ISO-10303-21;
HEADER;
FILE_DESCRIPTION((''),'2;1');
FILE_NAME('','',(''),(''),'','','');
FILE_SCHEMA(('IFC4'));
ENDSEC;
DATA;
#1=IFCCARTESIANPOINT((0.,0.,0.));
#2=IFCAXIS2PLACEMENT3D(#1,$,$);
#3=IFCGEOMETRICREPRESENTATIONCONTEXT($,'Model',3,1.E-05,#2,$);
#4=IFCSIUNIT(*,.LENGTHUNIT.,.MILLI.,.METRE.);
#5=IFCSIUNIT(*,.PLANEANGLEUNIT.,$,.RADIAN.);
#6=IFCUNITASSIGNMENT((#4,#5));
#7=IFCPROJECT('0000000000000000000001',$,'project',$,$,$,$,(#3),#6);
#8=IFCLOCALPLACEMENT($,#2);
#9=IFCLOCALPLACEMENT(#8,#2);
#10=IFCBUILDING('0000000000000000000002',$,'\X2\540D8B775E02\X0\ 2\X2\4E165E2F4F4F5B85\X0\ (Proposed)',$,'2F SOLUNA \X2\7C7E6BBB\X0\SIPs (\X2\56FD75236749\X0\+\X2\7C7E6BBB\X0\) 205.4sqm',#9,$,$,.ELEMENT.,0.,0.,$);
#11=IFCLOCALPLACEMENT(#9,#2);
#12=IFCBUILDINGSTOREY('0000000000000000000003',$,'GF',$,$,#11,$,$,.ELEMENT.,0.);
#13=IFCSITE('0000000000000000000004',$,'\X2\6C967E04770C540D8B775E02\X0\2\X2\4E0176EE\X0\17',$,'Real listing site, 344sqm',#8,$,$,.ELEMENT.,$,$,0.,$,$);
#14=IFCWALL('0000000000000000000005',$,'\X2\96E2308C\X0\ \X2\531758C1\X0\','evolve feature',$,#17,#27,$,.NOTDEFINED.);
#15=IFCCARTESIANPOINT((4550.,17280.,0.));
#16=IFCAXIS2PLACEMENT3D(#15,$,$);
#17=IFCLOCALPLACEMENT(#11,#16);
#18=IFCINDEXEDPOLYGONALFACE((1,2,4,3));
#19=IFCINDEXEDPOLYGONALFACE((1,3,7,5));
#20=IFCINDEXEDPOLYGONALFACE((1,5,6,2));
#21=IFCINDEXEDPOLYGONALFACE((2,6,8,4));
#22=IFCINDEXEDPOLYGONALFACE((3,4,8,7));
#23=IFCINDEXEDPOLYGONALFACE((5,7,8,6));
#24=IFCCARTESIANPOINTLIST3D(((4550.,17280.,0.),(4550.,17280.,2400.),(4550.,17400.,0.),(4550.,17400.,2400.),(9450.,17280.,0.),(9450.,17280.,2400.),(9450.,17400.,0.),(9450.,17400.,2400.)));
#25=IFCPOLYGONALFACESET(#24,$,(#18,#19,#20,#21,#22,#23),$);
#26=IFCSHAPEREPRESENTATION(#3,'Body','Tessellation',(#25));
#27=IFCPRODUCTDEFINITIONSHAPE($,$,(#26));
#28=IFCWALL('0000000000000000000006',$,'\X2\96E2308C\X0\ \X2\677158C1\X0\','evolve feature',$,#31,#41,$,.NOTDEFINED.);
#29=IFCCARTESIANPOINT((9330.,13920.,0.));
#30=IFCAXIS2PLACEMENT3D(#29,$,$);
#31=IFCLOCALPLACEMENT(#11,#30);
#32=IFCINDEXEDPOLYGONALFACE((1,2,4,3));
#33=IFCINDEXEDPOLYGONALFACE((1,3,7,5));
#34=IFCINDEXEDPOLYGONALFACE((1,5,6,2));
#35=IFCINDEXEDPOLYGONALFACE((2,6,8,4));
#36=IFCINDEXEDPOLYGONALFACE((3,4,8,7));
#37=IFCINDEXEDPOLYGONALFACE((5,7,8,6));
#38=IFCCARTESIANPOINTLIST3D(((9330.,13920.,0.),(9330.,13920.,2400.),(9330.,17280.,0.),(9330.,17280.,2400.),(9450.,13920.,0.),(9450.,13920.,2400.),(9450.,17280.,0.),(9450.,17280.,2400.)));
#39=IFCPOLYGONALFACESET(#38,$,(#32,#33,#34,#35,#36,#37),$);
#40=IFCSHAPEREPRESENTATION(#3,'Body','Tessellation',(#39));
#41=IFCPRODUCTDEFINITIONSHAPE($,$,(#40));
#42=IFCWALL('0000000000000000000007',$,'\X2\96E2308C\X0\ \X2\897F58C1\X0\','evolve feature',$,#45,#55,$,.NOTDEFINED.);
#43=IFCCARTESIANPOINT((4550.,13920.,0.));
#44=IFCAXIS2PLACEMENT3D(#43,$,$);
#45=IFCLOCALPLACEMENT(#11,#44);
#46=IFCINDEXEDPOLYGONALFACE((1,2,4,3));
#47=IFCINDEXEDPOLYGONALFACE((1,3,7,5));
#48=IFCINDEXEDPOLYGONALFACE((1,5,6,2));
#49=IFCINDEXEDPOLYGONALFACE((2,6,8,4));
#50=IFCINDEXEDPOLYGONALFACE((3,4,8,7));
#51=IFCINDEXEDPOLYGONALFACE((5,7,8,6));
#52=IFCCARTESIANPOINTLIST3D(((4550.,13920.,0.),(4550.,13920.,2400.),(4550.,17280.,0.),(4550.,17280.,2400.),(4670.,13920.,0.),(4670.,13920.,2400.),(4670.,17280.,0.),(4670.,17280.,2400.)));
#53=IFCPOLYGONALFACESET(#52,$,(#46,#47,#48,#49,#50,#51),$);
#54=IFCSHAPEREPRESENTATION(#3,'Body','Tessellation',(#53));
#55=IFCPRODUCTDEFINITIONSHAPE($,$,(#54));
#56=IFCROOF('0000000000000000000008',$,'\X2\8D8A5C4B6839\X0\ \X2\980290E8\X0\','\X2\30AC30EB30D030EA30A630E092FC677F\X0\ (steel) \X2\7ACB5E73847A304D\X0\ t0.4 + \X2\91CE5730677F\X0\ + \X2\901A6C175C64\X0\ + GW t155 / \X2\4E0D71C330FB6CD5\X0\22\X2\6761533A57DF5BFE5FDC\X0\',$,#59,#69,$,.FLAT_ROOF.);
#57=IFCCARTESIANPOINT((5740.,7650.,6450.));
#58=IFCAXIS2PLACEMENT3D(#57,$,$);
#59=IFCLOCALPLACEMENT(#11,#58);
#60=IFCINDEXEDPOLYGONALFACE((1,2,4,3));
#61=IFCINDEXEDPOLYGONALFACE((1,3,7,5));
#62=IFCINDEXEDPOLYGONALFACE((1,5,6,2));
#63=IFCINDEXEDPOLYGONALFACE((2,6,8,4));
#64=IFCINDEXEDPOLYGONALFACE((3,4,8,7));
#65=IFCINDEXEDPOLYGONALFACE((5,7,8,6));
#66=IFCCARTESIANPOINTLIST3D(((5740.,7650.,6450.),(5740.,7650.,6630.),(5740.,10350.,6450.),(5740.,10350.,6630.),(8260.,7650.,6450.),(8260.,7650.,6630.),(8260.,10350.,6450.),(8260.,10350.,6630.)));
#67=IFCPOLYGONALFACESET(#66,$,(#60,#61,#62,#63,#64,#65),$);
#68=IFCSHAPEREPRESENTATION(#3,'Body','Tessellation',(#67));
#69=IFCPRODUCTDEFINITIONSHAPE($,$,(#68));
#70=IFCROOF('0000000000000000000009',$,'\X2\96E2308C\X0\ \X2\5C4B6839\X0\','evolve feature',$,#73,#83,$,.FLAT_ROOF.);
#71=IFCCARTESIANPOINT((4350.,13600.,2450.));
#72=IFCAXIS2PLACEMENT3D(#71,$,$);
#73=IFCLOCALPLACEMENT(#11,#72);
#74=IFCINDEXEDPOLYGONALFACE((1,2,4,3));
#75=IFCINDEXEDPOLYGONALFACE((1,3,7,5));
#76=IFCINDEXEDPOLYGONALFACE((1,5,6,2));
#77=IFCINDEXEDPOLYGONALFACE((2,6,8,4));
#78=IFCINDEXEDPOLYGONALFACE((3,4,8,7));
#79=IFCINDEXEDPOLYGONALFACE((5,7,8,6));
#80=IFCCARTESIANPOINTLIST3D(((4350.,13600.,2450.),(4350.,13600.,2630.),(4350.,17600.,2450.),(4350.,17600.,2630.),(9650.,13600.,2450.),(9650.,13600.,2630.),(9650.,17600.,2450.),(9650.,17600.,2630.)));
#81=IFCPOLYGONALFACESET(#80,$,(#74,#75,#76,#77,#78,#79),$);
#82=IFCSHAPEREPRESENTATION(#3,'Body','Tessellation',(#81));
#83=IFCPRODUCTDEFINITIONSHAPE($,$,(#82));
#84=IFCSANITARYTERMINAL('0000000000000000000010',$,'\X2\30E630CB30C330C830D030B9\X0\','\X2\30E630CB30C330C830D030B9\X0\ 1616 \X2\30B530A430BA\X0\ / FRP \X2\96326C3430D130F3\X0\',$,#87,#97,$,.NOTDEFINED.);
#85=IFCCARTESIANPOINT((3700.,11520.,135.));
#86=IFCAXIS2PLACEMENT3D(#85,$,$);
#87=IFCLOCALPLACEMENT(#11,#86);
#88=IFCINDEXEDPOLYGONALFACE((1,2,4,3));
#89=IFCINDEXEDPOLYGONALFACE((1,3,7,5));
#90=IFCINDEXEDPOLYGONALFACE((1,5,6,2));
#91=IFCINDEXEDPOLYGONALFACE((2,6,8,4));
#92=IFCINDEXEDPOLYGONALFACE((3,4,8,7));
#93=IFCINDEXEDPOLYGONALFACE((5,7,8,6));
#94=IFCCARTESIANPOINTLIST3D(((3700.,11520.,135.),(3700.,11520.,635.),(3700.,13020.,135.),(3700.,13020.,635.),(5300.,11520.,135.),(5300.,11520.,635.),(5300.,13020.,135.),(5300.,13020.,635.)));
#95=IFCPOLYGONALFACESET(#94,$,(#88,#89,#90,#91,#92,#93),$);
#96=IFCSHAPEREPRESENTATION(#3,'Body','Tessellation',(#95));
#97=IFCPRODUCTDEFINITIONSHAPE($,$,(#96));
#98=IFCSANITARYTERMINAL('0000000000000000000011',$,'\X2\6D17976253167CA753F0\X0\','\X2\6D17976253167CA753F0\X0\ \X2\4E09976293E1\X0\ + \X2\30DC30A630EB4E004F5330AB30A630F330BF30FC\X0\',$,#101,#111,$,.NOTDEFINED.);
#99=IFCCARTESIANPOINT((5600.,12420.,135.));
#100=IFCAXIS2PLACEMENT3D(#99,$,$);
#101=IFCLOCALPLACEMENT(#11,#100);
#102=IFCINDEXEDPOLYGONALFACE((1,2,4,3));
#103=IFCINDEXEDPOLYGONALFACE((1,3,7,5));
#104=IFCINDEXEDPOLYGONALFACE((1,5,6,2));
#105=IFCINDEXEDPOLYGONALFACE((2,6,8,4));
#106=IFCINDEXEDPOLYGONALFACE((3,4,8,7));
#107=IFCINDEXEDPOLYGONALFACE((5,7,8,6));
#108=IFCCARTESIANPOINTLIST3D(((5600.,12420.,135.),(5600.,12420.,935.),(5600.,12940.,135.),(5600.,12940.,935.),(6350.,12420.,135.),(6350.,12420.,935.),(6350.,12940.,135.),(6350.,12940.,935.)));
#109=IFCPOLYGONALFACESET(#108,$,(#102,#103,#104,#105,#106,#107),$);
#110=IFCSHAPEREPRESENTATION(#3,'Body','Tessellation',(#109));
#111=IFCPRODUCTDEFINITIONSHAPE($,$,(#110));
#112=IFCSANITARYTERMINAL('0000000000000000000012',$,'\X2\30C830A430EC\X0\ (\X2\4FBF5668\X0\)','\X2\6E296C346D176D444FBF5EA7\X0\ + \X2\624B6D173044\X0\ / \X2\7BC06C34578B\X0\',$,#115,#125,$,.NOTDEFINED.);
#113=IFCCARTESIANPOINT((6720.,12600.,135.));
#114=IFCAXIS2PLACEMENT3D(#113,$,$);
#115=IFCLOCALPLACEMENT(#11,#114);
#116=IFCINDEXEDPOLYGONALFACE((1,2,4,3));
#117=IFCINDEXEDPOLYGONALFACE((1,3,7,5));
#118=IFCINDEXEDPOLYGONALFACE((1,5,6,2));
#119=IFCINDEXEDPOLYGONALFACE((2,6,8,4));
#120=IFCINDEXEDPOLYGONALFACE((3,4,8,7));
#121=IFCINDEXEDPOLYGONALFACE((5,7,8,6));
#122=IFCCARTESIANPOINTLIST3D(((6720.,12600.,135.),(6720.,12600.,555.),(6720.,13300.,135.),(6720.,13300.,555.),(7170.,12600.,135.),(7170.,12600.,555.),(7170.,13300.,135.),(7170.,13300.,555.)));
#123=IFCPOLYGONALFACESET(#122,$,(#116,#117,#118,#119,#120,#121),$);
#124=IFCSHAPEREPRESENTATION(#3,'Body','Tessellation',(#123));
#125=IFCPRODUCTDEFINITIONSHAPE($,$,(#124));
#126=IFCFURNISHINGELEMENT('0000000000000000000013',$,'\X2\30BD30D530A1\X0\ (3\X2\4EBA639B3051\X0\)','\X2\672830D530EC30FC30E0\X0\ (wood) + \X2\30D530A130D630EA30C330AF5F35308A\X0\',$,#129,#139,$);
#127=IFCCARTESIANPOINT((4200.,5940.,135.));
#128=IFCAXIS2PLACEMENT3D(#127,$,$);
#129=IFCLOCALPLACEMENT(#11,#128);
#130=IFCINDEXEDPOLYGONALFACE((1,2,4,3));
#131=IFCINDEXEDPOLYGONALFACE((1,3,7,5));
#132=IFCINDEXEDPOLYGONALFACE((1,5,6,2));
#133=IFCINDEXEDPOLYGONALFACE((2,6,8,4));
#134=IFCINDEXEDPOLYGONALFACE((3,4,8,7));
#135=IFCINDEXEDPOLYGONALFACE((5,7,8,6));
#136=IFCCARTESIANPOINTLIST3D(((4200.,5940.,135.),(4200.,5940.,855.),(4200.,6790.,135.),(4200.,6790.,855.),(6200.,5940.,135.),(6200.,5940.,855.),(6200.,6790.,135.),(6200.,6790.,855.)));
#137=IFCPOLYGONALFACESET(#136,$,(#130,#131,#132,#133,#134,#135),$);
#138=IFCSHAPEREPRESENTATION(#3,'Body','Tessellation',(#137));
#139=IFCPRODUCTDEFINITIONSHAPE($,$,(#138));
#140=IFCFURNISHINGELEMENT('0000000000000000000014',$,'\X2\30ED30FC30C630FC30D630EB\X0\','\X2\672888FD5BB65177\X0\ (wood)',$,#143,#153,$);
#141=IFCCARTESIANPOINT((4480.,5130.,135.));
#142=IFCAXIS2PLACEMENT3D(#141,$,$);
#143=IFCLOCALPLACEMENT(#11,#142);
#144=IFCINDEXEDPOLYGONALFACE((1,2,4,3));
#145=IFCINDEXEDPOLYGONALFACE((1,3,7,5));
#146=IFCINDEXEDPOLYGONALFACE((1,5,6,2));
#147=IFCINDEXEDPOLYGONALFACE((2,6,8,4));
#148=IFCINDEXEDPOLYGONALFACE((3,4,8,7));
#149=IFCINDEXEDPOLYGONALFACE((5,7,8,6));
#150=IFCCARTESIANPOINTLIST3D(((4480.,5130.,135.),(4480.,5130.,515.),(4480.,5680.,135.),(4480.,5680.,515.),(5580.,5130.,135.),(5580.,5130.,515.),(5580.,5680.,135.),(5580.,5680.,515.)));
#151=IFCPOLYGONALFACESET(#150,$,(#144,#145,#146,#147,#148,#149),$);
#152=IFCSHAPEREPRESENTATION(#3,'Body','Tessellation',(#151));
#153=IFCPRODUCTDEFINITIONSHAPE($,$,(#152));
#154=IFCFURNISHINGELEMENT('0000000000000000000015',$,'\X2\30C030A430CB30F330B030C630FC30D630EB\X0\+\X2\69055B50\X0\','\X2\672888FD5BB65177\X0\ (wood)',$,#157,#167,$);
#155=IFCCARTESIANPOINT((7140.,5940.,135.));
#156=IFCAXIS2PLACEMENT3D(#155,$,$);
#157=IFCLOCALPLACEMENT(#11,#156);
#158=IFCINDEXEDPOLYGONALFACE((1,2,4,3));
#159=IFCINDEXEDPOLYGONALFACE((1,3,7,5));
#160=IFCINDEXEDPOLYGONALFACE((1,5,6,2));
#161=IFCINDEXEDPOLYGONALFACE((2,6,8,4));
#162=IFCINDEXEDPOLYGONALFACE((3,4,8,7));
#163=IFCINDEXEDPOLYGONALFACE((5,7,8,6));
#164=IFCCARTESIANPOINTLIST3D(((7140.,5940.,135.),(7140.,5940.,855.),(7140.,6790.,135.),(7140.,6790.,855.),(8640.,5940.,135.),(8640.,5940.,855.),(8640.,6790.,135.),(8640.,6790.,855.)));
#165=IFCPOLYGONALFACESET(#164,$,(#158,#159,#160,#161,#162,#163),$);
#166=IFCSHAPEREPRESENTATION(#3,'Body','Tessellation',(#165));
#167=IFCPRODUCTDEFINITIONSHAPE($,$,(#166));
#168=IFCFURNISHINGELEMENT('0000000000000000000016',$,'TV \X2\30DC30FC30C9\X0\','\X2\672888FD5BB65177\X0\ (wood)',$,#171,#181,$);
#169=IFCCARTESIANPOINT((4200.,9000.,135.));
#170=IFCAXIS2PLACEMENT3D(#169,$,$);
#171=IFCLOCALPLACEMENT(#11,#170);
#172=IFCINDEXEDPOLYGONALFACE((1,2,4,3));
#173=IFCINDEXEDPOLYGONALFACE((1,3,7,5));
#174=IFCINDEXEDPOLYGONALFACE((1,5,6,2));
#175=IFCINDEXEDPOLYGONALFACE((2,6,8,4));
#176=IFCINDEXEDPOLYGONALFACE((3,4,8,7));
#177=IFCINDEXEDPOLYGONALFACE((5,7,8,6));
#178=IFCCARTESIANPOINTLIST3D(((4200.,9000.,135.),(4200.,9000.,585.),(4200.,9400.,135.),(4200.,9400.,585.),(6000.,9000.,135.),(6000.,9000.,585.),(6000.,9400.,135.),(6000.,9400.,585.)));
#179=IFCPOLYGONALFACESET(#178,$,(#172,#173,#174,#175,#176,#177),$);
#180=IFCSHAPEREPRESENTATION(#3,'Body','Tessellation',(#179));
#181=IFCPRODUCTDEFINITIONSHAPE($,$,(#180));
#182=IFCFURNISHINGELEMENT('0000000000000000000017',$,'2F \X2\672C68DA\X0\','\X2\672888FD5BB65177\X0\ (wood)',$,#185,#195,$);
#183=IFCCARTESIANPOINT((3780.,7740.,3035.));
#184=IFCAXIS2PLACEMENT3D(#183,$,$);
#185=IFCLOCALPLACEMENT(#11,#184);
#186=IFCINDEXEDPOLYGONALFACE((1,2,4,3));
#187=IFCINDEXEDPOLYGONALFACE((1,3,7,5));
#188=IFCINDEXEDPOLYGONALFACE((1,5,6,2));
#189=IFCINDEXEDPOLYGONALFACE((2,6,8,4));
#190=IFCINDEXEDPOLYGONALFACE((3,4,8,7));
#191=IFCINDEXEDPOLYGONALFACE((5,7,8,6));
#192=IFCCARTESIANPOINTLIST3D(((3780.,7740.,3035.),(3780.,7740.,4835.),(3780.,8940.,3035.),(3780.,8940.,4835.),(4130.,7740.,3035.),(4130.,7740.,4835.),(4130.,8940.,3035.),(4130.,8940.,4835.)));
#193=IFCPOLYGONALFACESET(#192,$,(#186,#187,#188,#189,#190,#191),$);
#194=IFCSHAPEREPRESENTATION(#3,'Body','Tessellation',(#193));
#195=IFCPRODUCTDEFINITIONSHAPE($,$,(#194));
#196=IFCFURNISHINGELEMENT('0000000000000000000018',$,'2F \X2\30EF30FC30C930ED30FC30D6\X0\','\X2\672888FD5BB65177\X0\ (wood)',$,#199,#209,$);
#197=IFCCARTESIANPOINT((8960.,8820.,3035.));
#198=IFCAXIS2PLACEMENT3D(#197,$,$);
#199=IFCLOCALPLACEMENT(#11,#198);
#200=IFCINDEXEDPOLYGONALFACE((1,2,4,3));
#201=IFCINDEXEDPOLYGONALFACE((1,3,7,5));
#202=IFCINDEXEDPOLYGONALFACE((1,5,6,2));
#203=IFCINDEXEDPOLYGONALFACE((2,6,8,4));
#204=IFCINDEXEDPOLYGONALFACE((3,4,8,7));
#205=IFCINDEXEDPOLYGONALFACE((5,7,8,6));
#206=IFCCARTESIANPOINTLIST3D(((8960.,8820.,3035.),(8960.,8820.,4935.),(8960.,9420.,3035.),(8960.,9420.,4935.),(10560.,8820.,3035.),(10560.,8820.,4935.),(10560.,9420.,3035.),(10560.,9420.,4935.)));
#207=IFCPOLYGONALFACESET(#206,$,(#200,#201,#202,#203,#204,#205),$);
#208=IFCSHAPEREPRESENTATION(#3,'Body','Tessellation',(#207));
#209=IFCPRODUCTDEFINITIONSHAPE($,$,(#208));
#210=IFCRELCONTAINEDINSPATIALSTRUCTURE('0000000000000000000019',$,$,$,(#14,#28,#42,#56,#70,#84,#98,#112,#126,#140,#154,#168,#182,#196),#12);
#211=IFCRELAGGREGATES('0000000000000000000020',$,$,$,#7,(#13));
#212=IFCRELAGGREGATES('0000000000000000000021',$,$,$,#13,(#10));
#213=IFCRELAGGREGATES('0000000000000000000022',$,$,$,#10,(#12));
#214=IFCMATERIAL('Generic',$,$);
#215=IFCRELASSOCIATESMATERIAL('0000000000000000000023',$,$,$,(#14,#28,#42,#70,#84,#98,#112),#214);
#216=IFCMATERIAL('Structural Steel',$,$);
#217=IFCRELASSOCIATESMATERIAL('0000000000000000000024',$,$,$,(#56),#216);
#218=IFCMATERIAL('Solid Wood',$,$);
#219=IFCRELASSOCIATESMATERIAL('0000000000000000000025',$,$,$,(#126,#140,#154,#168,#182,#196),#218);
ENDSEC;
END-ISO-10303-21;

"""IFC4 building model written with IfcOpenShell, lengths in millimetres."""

from ifc_helpers import new_model, si_unit, frame, frame_2d, origin, place, context, project, spatial, rectangle, extrude, material, element, save


model = new_model("IFC4")

# Units and contexts
model_context = context("Model", 3, precision=1e-05, world=origin())
ifc_project = project(units=[si_unit("LENGTHUNIT", "METRE", prefix="MILLI"), si_unit("PLANEANGLEUNIT", "RADIAN")], contexts=[model_context])

# Site, building, storey
site_placement = place(None, origin())
site = spatial("IfcSite", under=ifc_project, at=site_placement, Name="沖縄県名護市2丁目17", ObjectType="Real listing site, 344sqm", CompositionType="ELEMENT", RefElevation=0.0)
building_placement = place(site_placement, origin())
building = spatial("IfcBuilding", under=site, at=building_placement, Name="名護市 2世帯住宅 (Proposed)", ObjectType="2F SOLUNA 籾殻SIPs (国産杉+籾殻) 205.4sqm", CompositionType="ELEMENT", ElevationOfRefHeight=0.0, ElevationOfTerrain=0.0)
storey_placement = place(building_placement, origin())
storey = spatial("IfcBuildingStorey", under=building, at=storey_placement, Name="GF", CompositionType="ELEMENT", Elevation=0.0)

# Shared definitions
ifc_material_1 = material(Name="Generic")

# Shared definitions
ifc_material_2 = material(Name="Solid Wood")

# Walls
wall_1_placement = place(storey_placement, frame((4550.0, 17280.0, 0.0)))
element("IfcWall", 1, at=wall_1_placement, inside=storey, material=ifc_material_1, Name="離れ 北壁", Description="evolve feature", PredefinedType="NOTDEFINED", context=model_context, shape_type="SweptSolid", body=[
    extrude(rectangle(XDim=4900.0, YDim=120.0, at=frame_2d((2450.0, 60.0))), frame((4550.0, 17280.0, 0.0)), (0.0, 0.0, 1.0), 2400.0),
])
wall_2_placement = place(storey_placement, frame((9330.0, 13920.0, 0.0)))
element("IfcWall", 2, at=wall_2_placement, inside=storey, material=ifc_material_1, Name="離れ 東壁", Description="evolve feature", PredefinedType="NOTDEFINED", context=model_context, shape_type="SweptSolid", body=[
    extrude(rectangle(XDim=120.0, YDim=3360.0, at=frame_2d((60.0, 1680.0))), frame((9330.0, 13920.0, 0.0)), (0.0, 0.0, 1.0), 2400.0),
])
wall_3_placement = place(storey_placement, frame((4550.0, 13920.0, 0.0)))
element("IfcWall", 3, at=wall_3_placement, inside=storey, material=ifc_material_1, Name="離れ 西壁", Description="evolve feature", PredefinedType="NOTDEFINED", context=model_context, shape_type="SweptSolid", body=[
    extrude(rectangle(XDim=120.0, YDim=3360.0, at=frame_2d((60.0, 1680.0))), frame((4550.0, 13920.0, 0.0)), (0.0, 0.0, 1.0), 2400.0),
])

# Roofs
ifc_material_3 = material(Name="Structural Steel")
roof_1_placement = place(storey_placement, frame((5740.0, 7650.0, 6450.0)))
element("IfcRoof", 4, at=roof_1_placement, inside=storey, material=ifc_material_3, Name="越屋根 頂部", Description="ガルバリウム鋼板 (steel) 立平葺き t0.4 + 野地板 + 通気層 + GW t155 / 不燃・法22条区域対応", PredefinedType="FLAT_ROOF", context=model_context, shape_type="SweptSolid", body=[
    extrude(rectangle(XDim=2520.0, YDim=2700.0, at=frame_2d((1260.0, 1350.0))), frame((5740.0, 7650.0, 6450.0)), (0.0, 0.0, 1.0), 180.0),
])
roof_2_placement = place(storey_placement, frame((4350.0, 13600.0, 2450.0)))
element("IfcRoof", 5, at=roof_2_placement, inside=storey, material=ifc_material_1, Name="離れ 屋根", Description="evolve feature", PredefinedType="FLAT_ROOF", context=model_context, shape_type="SweptSolid", body=[
    extrude(rectangle(XDim=5300.0, YDim=4000.0, at=frame_2d((2650.0, 2000.0))), frame((4350.0, 13600.0, 2450.0)), (0.0, 0.0, 1.0), 180.0),
])

# Sanitary terminals
sanitary_terminal_1_placement = place(storey_placement, frame((3700.0, 11520.0, 135.0)))
element("IfcSanitaryTerminal", 6, at=sanitary_terminal_1_placement, inside=storey, material=ifc_material_1, Name="ユニットバス", Description="ユニットバス 1616 サイズ / FRP 防水パン", PredefinedType="NOTDEFINED", context=model_context, shape_type="SweptSolid", body=[
    extrude(rectangle(XDim=1600.0, YDim=1500.0, at=frame_2d((800.0, 750.0))), frame((3700.0, 11520.0, 135.0)), (0.0, 0.0, 1.0), 500.0),
])
sanitary_terminal_2_placement = place(storey_placement, frame((5600.0, 12420.0, 135.0)))
element("IfcSanitaryTerminal", 7, at=sanitary_terminal_2_placement, inside=storey, material=ifc_material_1, Name="洗面化粧台", Description="洗面化粧台 三面鏡 + ボウル一体カウンター", PredefinedType="NOTDEFINED", context=model_context, shape_type="SweptSolid", body=[
    extrude(rectangle(XDim=750.0, YDim=520.0, at=frame_2d((375.0, 260.0))), frame((5600.0, 12420.0, 135.0)), (0.0, 0.0, 1.0), 800.0),
])
sanitary_terminal_3_placement = place(storey_placement, frame((6720.0, 12600.0, 135.0)))
element("IfcSanitaryTerminal", 8, at=sanitary_terminal_3_placement, inside=storey, material=ifc_material_1, Name="トイレ (便器)", Description="温水洗浄便座 + 手洗い / 節水型", PredefinedType="NOTDEFINED", context=model_context, shape_type="SweptSolid", body=[
    extrude(rectangle(XDim=450.0, YDim=700.0, at=frame_2d((225.0, 350.0))), frame((6720.0, 12600.0, 135.0)), (0.0, 0.0, 1.0), 420.0),
])

# Furnishing elements
furnishing_1_placement = place(storey_placement, frame((4200.0, 5940.0, 135.0)))
element("IfcFurnishingElement", 9, at=furnishing_1_placement, inside=storey, material=ifc_material_2, Name="ソファ (3人掛け)", Description="木フレーム (wood) + ファブリック張り", context=model_context, shape_type="SweptSolid", body=[
    extrude(rectangle(XDim=2000.0, YDim=850.0, at=frame_2d((1000.0, 425.0))), frame((4200.0, 5940.0, 135.0)), (0.0, 0.0, 1.0), 720.0),
])
furnishing_2_placement = place(storey_placement, frame((4480.0, 5130.0, 135.0)))
element("IfcFurnishingElement", 10, at=furnishing_2_placement, inside=storey, material=ifc_material_2, Name="ローテーブル", Description="木製家具 (wood)", context=model_context, shape_type="SweptSolid", body=[
    extrude(rectangle(XDim=1100.0, YDim=550.0, at=frame_2d((550.0, 275.0))), frame((4480.0, 5130.0, 135.0)), (0.0, 0.0, 1.0), 380.0),
])
furnishing_3_placement = place(storey_placement, frame((7140.0, 5940.0, 135.0)))
element("IfcFurnishingElement", 11, at=furnishing_3_placement, inside=storey, material=ifc_material_2, Name="ダイニングテーブル+椅子", Description="木製家具 (wood)", context=model_context, shape_type="SweptSolid", body=[
    extrude(rectangle(XDim=1500.0, YDim=850.0, at=frame_2d((750.0, 425.0))), frame((7140.0, 5940.0, 135.0)), (0.0, 0.0, 1.0), 720.0),
])
furnishing_4_placement = place(storey_placement, frame((4200.0, 9000.0, 135.0)))
element("IfcFurnishingElement", 12, at=furnishing_4_placement, inside=storey, material=ifc_material_2, Name="TV ボード", Description="木製家具 (wood)", context=model_context, shape_type="SweptSolid", body=[
    extrude(rectangle(XDim=1800.0, YDim=400.0, at=frame_2d((900.0, 200.0))), frame((4200.0, 9000.0, 135.0)), (0.0, 0.0, 1.0), 450.0),
])
furnishing_5_placement = place(storey_placement, frame((3780.0, 7740.0, 3035.0)))
element("IfcFurnishingElement", 13, at=furnishing_5_placement, inside=storey, material=ifc_material_2, Name="2F 本棚", Description="木製家具 (wood)", context=model_context, shape_type="SweptSolid", body=[
    extrude(rectangle(XDim=350.0, YDim=1200.0, at=frame_2d((175.0, 600.0))), frame((3780.0, 7740.0, 3035.0)), (0.0, 0.0, 1.0), 1800.0),
])
furnishing_6_placement = place(storey_placement, frame((8960.0, 8820.0, 3035.0)))
element("IfcFurnishingElement", 14, at=furnishing_6_placement, inside=storey, material=ifc_material_2, Name="2F ワードローブ", Description="木製家具 (wood)", context=model_context, shape_type="SweptSolid", body=[
    extrude(rectangle(XDim=1600.0, YDim=600.0, at=frame_2d((800.0, 300.0))), frame((8960.0, 8820.0, 3035.0)), (0.0, 0.0, 1.0), 1900.0),
])

save(model, "model.ifc")
